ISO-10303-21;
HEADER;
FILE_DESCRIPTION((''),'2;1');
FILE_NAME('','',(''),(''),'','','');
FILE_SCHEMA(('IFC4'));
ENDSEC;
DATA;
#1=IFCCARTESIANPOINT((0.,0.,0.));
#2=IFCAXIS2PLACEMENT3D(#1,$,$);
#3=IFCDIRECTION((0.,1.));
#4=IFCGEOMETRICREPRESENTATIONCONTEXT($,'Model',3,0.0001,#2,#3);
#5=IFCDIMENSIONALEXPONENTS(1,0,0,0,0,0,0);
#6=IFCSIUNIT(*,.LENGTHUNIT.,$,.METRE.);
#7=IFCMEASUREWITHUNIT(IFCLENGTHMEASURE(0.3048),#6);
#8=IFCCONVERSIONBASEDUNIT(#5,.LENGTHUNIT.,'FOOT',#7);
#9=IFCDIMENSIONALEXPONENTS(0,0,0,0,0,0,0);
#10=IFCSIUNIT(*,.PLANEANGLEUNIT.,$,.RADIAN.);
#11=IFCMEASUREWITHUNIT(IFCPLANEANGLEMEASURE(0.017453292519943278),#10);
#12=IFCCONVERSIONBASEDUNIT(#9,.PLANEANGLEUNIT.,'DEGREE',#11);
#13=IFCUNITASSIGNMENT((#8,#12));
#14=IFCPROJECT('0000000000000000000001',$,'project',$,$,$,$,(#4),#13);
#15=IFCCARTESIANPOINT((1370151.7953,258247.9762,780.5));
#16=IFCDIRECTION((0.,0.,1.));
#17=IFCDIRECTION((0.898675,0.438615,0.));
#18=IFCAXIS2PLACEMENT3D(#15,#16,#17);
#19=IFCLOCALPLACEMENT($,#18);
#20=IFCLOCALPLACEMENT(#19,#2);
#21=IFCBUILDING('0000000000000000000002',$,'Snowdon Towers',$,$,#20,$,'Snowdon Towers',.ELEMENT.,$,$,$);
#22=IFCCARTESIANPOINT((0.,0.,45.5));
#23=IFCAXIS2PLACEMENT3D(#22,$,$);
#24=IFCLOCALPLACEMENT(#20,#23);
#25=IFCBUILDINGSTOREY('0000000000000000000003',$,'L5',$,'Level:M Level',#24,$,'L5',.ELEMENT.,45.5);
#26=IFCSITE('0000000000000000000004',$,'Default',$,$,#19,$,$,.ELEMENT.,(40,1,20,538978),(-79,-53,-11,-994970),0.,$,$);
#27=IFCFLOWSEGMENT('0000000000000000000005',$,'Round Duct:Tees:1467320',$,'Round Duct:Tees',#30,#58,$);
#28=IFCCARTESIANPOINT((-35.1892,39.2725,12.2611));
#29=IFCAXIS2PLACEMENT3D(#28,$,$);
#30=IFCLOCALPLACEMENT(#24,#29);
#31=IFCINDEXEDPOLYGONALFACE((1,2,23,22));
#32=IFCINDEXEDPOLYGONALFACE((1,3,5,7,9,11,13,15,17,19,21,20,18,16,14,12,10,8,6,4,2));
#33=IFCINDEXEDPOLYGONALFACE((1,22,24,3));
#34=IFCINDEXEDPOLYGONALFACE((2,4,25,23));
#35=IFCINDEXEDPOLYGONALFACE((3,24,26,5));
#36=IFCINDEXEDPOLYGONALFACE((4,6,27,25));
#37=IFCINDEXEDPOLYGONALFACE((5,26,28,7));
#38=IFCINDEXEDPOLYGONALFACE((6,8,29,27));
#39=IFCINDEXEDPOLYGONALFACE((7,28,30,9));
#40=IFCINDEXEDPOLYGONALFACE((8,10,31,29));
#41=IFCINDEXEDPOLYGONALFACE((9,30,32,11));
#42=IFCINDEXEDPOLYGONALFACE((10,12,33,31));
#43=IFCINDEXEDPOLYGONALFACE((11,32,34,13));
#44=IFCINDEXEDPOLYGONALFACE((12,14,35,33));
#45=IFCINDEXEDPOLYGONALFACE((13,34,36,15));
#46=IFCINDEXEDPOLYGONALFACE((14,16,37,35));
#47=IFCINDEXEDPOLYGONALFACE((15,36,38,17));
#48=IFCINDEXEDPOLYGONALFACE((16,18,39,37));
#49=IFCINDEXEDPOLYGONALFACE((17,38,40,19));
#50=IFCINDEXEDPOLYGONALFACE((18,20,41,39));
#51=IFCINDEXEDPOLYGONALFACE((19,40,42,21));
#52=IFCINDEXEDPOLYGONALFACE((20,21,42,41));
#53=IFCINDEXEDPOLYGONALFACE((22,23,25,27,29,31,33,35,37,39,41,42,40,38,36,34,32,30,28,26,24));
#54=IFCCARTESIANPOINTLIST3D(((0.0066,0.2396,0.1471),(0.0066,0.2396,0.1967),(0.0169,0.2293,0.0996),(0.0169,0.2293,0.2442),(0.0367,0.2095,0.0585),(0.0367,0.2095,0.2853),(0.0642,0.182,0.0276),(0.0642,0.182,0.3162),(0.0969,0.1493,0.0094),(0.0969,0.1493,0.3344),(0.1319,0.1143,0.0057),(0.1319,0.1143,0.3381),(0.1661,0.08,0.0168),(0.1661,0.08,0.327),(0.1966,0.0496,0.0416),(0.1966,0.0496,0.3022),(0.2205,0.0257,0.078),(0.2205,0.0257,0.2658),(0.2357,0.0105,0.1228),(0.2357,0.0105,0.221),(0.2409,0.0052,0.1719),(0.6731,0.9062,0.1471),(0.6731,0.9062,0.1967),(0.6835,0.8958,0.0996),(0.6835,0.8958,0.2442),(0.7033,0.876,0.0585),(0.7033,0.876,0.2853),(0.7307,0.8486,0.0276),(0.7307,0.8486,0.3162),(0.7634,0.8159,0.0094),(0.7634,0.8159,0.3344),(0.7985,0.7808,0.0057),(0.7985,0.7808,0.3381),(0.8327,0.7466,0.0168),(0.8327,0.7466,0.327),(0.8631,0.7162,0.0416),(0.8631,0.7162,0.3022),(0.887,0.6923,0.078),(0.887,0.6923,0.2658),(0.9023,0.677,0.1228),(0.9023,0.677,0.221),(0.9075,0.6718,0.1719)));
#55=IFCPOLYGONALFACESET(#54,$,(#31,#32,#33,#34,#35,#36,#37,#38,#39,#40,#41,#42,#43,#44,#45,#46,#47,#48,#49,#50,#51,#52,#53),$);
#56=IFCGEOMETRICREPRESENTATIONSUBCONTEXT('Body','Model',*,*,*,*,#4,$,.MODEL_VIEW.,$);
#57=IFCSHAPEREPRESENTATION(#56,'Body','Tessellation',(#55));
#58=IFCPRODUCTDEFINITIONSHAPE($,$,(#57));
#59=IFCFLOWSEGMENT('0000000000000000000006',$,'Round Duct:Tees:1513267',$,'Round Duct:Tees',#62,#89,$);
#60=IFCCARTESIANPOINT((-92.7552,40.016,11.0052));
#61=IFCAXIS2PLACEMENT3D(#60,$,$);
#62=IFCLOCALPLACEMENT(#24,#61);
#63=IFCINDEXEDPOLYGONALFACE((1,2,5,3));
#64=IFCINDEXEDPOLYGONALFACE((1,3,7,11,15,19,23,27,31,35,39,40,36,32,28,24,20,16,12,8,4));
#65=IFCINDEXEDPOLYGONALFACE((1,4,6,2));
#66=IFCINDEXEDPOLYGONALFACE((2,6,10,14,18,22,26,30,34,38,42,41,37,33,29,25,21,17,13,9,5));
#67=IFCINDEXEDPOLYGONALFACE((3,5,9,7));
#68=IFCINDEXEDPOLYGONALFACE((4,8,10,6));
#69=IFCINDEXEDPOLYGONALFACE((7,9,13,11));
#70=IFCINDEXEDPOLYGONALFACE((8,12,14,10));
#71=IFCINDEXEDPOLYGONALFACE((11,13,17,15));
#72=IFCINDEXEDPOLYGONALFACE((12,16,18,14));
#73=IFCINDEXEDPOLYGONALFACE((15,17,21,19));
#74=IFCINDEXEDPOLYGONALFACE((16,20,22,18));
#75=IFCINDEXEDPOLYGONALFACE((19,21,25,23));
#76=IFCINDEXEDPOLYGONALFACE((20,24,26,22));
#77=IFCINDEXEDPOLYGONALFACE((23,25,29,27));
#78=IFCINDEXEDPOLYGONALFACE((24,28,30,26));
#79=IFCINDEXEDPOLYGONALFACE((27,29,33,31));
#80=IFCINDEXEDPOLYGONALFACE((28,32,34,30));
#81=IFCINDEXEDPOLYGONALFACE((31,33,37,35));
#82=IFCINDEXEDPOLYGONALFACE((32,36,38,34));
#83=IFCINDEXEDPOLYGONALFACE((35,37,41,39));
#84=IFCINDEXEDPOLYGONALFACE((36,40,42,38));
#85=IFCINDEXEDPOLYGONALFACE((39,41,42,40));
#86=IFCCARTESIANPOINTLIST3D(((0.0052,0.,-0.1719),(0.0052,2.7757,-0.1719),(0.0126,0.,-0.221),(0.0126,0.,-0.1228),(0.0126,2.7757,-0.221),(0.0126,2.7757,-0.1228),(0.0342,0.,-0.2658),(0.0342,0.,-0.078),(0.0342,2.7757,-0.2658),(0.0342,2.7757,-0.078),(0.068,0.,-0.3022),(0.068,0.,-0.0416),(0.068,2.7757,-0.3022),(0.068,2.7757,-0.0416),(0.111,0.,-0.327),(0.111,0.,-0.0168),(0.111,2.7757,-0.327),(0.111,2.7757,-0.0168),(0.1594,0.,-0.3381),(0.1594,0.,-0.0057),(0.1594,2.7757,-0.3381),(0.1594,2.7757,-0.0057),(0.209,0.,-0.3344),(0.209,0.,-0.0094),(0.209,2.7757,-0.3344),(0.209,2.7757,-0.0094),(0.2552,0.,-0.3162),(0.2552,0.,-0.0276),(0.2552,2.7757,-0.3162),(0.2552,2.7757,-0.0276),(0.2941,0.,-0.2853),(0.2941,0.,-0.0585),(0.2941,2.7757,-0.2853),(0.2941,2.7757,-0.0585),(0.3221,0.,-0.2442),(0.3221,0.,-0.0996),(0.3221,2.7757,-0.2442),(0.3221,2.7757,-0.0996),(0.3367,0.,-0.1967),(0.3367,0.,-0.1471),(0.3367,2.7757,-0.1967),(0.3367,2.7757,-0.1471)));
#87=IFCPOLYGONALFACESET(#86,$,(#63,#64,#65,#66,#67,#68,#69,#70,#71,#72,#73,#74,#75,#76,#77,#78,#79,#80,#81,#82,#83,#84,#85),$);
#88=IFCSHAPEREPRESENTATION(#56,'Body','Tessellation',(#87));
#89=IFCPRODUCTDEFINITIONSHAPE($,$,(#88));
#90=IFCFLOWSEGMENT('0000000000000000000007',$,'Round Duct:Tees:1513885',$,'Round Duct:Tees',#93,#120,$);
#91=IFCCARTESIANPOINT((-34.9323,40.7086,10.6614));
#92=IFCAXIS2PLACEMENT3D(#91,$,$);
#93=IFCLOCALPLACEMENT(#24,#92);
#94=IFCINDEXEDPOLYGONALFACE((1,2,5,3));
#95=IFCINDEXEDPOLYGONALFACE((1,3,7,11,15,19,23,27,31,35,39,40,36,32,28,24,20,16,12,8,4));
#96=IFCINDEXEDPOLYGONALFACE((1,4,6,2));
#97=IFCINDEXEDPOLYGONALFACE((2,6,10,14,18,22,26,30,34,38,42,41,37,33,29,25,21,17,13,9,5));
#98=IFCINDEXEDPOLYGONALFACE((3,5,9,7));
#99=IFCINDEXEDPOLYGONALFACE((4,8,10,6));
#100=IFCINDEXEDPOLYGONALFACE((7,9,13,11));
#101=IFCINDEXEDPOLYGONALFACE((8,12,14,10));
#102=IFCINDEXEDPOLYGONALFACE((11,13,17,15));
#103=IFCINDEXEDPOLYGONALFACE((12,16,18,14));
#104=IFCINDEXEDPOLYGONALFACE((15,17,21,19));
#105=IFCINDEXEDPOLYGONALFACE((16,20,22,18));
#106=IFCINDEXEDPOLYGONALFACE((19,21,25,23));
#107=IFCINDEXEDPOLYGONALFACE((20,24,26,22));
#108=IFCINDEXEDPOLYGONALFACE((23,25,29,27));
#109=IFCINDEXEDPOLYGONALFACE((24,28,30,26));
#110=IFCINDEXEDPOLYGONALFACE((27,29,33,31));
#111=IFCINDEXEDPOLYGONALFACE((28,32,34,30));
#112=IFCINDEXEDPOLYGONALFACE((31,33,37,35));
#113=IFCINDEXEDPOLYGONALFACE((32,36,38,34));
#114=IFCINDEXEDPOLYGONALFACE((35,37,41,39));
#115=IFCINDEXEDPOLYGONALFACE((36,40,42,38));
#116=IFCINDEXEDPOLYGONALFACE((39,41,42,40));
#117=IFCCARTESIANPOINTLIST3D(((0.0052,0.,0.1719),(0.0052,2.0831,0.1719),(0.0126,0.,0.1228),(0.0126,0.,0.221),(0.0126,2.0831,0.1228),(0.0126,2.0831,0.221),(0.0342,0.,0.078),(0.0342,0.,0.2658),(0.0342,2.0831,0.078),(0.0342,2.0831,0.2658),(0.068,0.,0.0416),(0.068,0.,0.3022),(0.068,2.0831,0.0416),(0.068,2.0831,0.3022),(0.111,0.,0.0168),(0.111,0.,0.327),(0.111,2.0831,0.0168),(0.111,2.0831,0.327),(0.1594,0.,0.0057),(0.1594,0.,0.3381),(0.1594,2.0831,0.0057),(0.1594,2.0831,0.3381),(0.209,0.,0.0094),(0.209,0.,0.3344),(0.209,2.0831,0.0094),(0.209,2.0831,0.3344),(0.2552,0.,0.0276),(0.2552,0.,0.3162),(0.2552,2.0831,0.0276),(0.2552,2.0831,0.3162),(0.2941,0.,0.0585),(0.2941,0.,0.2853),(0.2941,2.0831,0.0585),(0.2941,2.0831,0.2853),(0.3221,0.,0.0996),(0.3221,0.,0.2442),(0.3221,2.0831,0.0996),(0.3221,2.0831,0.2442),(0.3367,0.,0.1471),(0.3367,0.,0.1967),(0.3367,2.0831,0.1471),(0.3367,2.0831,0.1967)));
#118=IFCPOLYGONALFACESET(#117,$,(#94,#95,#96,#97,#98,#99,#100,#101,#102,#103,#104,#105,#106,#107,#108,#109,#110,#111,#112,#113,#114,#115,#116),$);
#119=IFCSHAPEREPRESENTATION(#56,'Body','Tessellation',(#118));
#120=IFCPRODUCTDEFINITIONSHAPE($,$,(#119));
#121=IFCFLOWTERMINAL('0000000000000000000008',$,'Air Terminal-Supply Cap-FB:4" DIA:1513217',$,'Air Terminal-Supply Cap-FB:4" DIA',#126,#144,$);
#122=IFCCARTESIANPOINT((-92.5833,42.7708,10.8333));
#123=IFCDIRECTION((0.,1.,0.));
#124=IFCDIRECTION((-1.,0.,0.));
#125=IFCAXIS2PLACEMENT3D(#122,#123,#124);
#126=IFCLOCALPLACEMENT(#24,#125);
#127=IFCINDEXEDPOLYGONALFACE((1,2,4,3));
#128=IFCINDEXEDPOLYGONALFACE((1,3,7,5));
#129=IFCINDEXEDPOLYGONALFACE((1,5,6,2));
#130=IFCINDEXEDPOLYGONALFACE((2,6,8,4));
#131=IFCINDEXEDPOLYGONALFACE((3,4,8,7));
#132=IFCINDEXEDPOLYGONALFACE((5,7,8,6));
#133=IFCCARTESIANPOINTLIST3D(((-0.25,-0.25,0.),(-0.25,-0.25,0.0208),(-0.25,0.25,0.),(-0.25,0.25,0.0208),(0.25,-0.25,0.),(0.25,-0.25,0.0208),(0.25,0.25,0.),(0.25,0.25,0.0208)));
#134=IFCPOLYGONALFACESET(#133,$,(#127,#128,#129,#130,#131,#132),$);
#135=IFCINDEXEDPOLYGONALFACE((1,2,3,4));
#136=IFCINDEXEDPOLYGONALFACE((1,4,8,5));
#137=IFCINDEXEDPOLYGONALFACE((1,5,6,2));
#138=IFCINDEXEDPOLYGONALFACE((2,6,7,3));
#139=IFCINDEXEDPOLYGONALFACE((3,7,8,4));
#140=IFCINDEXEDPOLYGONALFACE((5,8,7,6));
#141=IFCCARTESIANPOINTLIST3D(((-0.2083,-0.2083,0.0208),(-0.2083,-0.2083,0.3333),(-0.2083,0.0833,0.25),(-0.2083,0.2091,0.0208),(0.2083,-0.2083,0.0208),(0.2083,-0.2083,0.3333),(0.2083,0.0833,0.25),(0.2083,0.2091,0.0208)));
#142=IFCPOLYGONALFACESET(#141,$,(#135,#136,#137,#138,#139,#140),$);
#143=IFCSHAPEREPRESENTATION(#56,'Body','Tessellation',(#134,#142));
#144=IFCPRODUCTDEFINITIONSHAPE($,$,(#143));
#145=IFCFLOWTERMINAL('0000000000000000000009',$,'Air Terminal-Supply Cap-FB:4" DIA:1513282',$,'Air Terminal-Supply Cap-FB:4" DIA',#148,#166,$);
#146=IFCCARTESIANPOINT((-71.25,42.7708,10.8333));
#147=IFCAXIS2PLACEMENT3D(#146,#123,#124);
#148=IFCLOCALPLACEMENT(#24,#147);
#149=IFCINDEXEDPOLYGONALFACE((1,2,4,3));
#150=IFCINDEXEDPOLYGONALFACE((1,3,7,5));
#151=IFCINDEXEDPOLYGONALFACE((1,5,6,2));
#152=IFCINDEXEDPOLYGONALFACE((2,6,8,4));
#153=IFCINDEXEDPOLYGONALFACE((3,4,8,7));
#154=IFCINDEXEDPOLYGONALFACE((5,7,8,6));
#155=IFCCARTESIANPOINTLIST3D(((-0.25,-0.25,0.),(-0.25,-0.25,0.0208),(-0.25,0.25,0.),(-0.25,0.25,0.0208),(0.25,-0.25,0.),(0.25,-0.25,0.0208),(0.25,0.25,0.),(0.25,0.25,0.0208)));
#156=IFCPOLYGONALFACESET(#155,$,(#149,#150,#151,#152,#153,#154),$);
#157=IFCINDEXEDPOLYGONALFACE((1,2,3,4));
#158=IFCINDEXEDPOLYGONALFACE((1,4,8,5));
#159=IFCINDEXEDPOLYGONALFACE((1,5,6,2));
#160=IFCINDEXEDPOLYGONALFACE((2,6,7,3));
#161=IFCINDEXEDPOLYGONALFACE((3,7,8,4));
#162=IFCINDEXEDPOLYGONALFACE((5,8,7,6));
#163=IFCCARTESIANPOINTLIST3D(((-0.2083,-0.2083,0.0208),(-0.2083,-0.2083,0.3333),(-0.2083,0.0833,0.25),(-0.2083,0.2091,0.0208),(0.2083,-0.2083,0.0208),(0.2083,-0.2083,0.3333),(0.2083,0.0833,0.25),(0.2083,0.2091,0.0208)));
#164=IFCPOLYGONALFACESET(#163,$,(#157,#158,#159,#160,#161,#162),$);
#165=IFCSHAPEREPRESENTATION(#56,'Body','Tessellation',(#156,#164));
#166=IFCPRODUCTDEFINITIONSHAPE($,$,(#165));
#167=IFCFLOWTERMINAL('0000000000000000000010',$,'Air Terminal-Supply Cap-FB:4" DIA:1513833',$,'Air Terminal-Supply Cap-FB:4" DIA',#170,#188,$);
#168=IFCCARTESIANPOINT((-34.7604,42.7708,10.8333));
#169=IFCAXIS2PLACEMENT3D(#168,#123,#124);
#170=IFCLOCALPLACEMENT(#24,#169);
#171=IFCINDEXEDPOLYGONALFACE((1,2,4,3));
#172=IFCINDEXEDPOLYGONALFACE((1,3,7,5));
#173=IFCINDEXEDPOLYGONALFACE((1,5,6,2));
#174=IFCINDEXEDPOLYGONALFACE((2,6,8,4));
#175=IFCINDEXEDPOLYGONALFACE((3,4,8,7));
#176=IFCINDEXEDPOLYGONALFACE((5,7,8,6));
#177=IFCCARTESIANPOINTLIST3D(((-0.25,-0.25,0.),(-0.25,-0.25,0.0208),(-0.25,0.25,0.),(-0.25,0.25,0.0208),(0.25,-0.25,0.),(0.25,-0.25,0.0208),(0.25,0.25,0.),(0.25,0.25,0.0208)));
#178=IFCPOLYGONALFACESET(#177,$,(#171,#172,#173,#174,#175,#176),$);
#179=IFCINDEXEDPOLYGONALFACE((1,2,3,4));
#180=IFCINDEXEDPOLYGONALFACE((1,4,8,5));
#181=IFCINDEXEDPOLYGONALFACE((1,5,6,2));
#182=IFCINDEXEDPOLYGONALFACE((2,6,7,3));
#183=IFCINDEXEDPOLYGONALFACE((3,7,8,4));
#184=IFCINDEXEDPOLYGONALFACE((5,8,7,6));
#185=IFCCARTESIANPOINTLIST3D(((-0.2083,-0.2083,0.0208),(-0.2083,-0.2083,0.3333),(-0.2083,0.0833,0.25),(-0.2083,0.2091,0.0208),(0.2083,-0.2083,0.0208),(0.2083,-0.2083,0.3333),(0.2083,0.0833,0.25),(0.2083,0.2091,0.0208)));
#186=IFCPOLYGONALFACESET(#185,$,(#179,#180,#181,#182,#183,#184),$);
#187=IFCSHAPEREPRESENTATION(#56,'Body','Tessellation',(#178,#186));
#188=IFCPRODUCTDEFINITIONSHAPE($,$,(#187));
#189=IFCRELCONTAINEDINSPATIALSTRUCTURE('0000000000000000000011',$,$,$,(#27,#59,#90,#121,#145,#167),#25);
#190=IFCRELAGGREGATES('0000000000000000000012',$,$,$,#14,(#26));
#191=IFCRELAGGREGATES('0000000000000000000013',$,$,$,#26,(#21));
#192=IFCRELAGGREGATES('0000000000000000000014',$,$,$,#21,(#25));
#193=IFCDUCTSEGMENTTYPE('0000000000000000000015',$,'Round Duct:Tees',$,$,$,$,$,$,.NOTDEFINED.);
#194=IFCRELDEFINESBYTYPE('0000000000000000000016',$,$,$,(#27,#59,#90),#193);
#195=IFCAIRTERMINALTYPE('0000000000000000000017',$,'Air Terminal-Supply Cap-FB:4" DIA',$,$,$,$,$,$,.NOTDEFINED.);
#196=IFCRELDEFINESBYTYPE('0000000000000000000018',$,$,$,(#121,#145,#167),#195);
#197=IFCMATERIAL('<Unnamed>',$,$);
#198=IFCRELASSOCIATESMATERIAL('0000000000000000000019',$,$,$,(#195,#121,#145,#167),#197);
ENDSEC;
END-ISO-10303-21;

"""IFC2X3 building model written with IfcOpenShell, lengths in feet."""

from ifc_helpers import new_model, entity, si_unit, converted_unit, direction, frame, frame_2d, origin, origin_2d_with_axis, place, context, subcontext, project, spatial, polyline, rectangle, circle, outline, extrude, source, transform, mapped, material, type_object, type_shapes, element, save


model = new_model("IFC2X3")

# Units and contexts
model_context = context("Model", 3, precision=0.0001, world=origin(), true_north=direction((0.0, 1.0)))
body_context = subcontext(model_context, "Body", "Model", "MODEL_VIEW")
ifc_project = project(units=[converted_unit("LENGTHUNIT", "FOOT", entity("IfcLengthMeasure", 0.3048), si_unit("LENGTHUNIT", "METRE"), dimensions=[1, 0, 0, 0, 0, 0, 0]), converted_unit("PLANEANGLEUNIT", "DEGREE", entity("IfcPlaneAngleMeasure", 0.017453292519943278), si_unit("PLANEANGLEUNIT", "RADIAN"), dimensions=[0, 0, 0, 0, 0, 0, 0])], contexts=[model_context])

# Site, building, storey
site_placement = place(None, frame((1370151.7953, 258247.9762, 780.5), z_axis=(0.0, 0.0, 1.0), x_axis=(0.898675, 0.438615, 0.0)))
site = spatial("IfcSite", under=ifc_project, at=site_placement, Name="Default", CompositionType="ELEMENT", RefLatitude=(40, 1, 20, 538978), RefLongitude=(-79, -53, -11, -994970), RefElevation=0.0)
building_placement = place(site_placement, origin())
building = spatial("IfcBuilding", under=site, at=building_placement, Name="Snowdon Towers", LongName="Snowdon Towers", CompositionType="ELEMENT")
storey_placement = place(building_placement, frame((0.0, 0.0, 45.5)))
storey = spatial("IfcBuildingStorey", under=building, at=storey_placement, Name="L5", ObjectType="Level:M Level", LongName="L5", CompositionType="ELEMENT", Elevation=45.5)

# Flow segments
duct_segment_type = type_object("IfcDuctSegmentType", Name="Round Duct:Tees", PredefinedType="NOTDEFINED")
flow_segment_1_placement = place(storey_placement, frame((-35.1892, 39.2725, 12.2611)))
element("IfcFlowSegment", 1, at=flow_segment_1_placement, inside=storey, type_object=duct_segment_type, Name="Round Duct:Tees:1467320", ObjectType="Round Duct:Tees", context=body_context, shape_type="SweptSolid", body=[
    extrude(circle(Radius=0.1667, at=origin_2d_with_axis()), frame((0.1231, 0.1231, 0.1719), z_axis=(0.707107, 0.707107, 0.0), x_axis=(0.707107, -0.707107, 0.0)), (0.0, 0.0, 1.0), 0.9427),
])
flow_segment_2_placement = place(storey_placement, frame((-92.7552, 40.016, 11.0052)))
element("IfcFlowSegment", 2, at=flow_segment_2_placement, inside=storey, type_object=duct_segment_type, Name="Round Duct:Tees:1513267", ObjectType="Round Duct:Tees", context=body_context, shape_type="SweptSolid", body=[
    extrude(circle(Radius=0.1667, at=frame_2d((0.0, 0.0), x_axis=(1.0, 0.0))), frame((0.1719, 0.0, -0.1719), z_axis=(0.0, 1.0, 0.0), x_axis=(-1.0, 0.0, 0.0)), (0.0, 0.0, 1.0), 2.7757),
])
flow_segment_3_placement = place(storey_placement, frame((-34.9323, 40.7086, 10.6614)))
element("IfcFlowSegment", 3, at=flow_segment_3_placement, inside=storey, type_object=duct_segment_type, Name="Round Duct:Tees:1513885", ObjectType="Round Duct:Tees", context=body_context, shape_type="SweptSolid", body=[
    extrude(circle(Radius=0.1667, at=origin_2d_with_axis()), frame((0.1719, 0.0, 0.1719), z_axis=(0.0, 1.0, 0.0), x_axis=(-1.0, 0.0, 0.0)), (0.0, 0.0, 1.0), 2.0831),
])

# Flow terminals
ifc_material = material(Name="<Unnamed>")
air_terminal_type = type_object("IfcAirTerminalType", Name="Air Terminal-Supply Cap-FB:4\" DIA", PredefinedType="NOTDEFINED", material=ifc_material)
shared_shape_1 = source(origin(), body_context, "Body", "SweptSolid", [
    extrude(rectangle(XDim=0.5, YDim=0.5, at=origin_2d_with_axis()), frame((0.0, 0.0, 0.0), z_axis=(0.0, 0.0, 1.0), x_axis=(-1.0, 0.0, 0.0)), (0.0, 0.0, 1.0), 0.0208),
    extrude(outline(polyline([(-0.1771, -0.1773), (0.1354, -0.1773), (0.1354, 0.2402), (-0.0938, 0.1144), (-0.1771, -0.1773)])), frame((-0.2083, -0.0311, 0.1562), z_axis=(1.0, 0.0, 0.0), x_axis=(0.0, 0.0, -1.0)), (0.0, 0.0, 1.0), 0.4167),
])
type_shapes(air_terminal_type, [shared_shape_1])
for number, where, z_axis, x_axis, name in (
    (4, (-92.5833, 42.7708, 10.8333), (0.0, 1.0, 0.0), (-1.0, 0.0, 0.0), "Air Terminal-Supply Cap-FB:4\" DIA:1513217"),
    (5, (-71.25, 42.7708, 10.8333), (0.0, 1.0, 0.0), (-1.0, 0.0, 0.0), "Air Terminal-Supply Cap-FB:4\" DIA:1513282"),
    (6, (-34.7604, 42.7708, 10.8333), (0.0, 1.0, 0.0), (-1.0, 0.0, 0.0), "Air Terminal-Supply Cap-FB:4\" DIA:1513833"),
):
    element("IfcFlowTerminal", number, at=place(storey_placement, frame(where, z_axis=z_axis, x_axis=x_axis)), inside=storey, type_object=air_terminal_type, material=ifc_material, Name=name, ObjectType="Air Terminal-Supply Cap-FB:4\" DIA", context=body_context, shape_type="MappedRepresentation", body=[
        mapped(shared_shape_1, transform((0.0, 0.0, 0.0), scale=1.0)),
    ])

save(model, "model.ifc")
